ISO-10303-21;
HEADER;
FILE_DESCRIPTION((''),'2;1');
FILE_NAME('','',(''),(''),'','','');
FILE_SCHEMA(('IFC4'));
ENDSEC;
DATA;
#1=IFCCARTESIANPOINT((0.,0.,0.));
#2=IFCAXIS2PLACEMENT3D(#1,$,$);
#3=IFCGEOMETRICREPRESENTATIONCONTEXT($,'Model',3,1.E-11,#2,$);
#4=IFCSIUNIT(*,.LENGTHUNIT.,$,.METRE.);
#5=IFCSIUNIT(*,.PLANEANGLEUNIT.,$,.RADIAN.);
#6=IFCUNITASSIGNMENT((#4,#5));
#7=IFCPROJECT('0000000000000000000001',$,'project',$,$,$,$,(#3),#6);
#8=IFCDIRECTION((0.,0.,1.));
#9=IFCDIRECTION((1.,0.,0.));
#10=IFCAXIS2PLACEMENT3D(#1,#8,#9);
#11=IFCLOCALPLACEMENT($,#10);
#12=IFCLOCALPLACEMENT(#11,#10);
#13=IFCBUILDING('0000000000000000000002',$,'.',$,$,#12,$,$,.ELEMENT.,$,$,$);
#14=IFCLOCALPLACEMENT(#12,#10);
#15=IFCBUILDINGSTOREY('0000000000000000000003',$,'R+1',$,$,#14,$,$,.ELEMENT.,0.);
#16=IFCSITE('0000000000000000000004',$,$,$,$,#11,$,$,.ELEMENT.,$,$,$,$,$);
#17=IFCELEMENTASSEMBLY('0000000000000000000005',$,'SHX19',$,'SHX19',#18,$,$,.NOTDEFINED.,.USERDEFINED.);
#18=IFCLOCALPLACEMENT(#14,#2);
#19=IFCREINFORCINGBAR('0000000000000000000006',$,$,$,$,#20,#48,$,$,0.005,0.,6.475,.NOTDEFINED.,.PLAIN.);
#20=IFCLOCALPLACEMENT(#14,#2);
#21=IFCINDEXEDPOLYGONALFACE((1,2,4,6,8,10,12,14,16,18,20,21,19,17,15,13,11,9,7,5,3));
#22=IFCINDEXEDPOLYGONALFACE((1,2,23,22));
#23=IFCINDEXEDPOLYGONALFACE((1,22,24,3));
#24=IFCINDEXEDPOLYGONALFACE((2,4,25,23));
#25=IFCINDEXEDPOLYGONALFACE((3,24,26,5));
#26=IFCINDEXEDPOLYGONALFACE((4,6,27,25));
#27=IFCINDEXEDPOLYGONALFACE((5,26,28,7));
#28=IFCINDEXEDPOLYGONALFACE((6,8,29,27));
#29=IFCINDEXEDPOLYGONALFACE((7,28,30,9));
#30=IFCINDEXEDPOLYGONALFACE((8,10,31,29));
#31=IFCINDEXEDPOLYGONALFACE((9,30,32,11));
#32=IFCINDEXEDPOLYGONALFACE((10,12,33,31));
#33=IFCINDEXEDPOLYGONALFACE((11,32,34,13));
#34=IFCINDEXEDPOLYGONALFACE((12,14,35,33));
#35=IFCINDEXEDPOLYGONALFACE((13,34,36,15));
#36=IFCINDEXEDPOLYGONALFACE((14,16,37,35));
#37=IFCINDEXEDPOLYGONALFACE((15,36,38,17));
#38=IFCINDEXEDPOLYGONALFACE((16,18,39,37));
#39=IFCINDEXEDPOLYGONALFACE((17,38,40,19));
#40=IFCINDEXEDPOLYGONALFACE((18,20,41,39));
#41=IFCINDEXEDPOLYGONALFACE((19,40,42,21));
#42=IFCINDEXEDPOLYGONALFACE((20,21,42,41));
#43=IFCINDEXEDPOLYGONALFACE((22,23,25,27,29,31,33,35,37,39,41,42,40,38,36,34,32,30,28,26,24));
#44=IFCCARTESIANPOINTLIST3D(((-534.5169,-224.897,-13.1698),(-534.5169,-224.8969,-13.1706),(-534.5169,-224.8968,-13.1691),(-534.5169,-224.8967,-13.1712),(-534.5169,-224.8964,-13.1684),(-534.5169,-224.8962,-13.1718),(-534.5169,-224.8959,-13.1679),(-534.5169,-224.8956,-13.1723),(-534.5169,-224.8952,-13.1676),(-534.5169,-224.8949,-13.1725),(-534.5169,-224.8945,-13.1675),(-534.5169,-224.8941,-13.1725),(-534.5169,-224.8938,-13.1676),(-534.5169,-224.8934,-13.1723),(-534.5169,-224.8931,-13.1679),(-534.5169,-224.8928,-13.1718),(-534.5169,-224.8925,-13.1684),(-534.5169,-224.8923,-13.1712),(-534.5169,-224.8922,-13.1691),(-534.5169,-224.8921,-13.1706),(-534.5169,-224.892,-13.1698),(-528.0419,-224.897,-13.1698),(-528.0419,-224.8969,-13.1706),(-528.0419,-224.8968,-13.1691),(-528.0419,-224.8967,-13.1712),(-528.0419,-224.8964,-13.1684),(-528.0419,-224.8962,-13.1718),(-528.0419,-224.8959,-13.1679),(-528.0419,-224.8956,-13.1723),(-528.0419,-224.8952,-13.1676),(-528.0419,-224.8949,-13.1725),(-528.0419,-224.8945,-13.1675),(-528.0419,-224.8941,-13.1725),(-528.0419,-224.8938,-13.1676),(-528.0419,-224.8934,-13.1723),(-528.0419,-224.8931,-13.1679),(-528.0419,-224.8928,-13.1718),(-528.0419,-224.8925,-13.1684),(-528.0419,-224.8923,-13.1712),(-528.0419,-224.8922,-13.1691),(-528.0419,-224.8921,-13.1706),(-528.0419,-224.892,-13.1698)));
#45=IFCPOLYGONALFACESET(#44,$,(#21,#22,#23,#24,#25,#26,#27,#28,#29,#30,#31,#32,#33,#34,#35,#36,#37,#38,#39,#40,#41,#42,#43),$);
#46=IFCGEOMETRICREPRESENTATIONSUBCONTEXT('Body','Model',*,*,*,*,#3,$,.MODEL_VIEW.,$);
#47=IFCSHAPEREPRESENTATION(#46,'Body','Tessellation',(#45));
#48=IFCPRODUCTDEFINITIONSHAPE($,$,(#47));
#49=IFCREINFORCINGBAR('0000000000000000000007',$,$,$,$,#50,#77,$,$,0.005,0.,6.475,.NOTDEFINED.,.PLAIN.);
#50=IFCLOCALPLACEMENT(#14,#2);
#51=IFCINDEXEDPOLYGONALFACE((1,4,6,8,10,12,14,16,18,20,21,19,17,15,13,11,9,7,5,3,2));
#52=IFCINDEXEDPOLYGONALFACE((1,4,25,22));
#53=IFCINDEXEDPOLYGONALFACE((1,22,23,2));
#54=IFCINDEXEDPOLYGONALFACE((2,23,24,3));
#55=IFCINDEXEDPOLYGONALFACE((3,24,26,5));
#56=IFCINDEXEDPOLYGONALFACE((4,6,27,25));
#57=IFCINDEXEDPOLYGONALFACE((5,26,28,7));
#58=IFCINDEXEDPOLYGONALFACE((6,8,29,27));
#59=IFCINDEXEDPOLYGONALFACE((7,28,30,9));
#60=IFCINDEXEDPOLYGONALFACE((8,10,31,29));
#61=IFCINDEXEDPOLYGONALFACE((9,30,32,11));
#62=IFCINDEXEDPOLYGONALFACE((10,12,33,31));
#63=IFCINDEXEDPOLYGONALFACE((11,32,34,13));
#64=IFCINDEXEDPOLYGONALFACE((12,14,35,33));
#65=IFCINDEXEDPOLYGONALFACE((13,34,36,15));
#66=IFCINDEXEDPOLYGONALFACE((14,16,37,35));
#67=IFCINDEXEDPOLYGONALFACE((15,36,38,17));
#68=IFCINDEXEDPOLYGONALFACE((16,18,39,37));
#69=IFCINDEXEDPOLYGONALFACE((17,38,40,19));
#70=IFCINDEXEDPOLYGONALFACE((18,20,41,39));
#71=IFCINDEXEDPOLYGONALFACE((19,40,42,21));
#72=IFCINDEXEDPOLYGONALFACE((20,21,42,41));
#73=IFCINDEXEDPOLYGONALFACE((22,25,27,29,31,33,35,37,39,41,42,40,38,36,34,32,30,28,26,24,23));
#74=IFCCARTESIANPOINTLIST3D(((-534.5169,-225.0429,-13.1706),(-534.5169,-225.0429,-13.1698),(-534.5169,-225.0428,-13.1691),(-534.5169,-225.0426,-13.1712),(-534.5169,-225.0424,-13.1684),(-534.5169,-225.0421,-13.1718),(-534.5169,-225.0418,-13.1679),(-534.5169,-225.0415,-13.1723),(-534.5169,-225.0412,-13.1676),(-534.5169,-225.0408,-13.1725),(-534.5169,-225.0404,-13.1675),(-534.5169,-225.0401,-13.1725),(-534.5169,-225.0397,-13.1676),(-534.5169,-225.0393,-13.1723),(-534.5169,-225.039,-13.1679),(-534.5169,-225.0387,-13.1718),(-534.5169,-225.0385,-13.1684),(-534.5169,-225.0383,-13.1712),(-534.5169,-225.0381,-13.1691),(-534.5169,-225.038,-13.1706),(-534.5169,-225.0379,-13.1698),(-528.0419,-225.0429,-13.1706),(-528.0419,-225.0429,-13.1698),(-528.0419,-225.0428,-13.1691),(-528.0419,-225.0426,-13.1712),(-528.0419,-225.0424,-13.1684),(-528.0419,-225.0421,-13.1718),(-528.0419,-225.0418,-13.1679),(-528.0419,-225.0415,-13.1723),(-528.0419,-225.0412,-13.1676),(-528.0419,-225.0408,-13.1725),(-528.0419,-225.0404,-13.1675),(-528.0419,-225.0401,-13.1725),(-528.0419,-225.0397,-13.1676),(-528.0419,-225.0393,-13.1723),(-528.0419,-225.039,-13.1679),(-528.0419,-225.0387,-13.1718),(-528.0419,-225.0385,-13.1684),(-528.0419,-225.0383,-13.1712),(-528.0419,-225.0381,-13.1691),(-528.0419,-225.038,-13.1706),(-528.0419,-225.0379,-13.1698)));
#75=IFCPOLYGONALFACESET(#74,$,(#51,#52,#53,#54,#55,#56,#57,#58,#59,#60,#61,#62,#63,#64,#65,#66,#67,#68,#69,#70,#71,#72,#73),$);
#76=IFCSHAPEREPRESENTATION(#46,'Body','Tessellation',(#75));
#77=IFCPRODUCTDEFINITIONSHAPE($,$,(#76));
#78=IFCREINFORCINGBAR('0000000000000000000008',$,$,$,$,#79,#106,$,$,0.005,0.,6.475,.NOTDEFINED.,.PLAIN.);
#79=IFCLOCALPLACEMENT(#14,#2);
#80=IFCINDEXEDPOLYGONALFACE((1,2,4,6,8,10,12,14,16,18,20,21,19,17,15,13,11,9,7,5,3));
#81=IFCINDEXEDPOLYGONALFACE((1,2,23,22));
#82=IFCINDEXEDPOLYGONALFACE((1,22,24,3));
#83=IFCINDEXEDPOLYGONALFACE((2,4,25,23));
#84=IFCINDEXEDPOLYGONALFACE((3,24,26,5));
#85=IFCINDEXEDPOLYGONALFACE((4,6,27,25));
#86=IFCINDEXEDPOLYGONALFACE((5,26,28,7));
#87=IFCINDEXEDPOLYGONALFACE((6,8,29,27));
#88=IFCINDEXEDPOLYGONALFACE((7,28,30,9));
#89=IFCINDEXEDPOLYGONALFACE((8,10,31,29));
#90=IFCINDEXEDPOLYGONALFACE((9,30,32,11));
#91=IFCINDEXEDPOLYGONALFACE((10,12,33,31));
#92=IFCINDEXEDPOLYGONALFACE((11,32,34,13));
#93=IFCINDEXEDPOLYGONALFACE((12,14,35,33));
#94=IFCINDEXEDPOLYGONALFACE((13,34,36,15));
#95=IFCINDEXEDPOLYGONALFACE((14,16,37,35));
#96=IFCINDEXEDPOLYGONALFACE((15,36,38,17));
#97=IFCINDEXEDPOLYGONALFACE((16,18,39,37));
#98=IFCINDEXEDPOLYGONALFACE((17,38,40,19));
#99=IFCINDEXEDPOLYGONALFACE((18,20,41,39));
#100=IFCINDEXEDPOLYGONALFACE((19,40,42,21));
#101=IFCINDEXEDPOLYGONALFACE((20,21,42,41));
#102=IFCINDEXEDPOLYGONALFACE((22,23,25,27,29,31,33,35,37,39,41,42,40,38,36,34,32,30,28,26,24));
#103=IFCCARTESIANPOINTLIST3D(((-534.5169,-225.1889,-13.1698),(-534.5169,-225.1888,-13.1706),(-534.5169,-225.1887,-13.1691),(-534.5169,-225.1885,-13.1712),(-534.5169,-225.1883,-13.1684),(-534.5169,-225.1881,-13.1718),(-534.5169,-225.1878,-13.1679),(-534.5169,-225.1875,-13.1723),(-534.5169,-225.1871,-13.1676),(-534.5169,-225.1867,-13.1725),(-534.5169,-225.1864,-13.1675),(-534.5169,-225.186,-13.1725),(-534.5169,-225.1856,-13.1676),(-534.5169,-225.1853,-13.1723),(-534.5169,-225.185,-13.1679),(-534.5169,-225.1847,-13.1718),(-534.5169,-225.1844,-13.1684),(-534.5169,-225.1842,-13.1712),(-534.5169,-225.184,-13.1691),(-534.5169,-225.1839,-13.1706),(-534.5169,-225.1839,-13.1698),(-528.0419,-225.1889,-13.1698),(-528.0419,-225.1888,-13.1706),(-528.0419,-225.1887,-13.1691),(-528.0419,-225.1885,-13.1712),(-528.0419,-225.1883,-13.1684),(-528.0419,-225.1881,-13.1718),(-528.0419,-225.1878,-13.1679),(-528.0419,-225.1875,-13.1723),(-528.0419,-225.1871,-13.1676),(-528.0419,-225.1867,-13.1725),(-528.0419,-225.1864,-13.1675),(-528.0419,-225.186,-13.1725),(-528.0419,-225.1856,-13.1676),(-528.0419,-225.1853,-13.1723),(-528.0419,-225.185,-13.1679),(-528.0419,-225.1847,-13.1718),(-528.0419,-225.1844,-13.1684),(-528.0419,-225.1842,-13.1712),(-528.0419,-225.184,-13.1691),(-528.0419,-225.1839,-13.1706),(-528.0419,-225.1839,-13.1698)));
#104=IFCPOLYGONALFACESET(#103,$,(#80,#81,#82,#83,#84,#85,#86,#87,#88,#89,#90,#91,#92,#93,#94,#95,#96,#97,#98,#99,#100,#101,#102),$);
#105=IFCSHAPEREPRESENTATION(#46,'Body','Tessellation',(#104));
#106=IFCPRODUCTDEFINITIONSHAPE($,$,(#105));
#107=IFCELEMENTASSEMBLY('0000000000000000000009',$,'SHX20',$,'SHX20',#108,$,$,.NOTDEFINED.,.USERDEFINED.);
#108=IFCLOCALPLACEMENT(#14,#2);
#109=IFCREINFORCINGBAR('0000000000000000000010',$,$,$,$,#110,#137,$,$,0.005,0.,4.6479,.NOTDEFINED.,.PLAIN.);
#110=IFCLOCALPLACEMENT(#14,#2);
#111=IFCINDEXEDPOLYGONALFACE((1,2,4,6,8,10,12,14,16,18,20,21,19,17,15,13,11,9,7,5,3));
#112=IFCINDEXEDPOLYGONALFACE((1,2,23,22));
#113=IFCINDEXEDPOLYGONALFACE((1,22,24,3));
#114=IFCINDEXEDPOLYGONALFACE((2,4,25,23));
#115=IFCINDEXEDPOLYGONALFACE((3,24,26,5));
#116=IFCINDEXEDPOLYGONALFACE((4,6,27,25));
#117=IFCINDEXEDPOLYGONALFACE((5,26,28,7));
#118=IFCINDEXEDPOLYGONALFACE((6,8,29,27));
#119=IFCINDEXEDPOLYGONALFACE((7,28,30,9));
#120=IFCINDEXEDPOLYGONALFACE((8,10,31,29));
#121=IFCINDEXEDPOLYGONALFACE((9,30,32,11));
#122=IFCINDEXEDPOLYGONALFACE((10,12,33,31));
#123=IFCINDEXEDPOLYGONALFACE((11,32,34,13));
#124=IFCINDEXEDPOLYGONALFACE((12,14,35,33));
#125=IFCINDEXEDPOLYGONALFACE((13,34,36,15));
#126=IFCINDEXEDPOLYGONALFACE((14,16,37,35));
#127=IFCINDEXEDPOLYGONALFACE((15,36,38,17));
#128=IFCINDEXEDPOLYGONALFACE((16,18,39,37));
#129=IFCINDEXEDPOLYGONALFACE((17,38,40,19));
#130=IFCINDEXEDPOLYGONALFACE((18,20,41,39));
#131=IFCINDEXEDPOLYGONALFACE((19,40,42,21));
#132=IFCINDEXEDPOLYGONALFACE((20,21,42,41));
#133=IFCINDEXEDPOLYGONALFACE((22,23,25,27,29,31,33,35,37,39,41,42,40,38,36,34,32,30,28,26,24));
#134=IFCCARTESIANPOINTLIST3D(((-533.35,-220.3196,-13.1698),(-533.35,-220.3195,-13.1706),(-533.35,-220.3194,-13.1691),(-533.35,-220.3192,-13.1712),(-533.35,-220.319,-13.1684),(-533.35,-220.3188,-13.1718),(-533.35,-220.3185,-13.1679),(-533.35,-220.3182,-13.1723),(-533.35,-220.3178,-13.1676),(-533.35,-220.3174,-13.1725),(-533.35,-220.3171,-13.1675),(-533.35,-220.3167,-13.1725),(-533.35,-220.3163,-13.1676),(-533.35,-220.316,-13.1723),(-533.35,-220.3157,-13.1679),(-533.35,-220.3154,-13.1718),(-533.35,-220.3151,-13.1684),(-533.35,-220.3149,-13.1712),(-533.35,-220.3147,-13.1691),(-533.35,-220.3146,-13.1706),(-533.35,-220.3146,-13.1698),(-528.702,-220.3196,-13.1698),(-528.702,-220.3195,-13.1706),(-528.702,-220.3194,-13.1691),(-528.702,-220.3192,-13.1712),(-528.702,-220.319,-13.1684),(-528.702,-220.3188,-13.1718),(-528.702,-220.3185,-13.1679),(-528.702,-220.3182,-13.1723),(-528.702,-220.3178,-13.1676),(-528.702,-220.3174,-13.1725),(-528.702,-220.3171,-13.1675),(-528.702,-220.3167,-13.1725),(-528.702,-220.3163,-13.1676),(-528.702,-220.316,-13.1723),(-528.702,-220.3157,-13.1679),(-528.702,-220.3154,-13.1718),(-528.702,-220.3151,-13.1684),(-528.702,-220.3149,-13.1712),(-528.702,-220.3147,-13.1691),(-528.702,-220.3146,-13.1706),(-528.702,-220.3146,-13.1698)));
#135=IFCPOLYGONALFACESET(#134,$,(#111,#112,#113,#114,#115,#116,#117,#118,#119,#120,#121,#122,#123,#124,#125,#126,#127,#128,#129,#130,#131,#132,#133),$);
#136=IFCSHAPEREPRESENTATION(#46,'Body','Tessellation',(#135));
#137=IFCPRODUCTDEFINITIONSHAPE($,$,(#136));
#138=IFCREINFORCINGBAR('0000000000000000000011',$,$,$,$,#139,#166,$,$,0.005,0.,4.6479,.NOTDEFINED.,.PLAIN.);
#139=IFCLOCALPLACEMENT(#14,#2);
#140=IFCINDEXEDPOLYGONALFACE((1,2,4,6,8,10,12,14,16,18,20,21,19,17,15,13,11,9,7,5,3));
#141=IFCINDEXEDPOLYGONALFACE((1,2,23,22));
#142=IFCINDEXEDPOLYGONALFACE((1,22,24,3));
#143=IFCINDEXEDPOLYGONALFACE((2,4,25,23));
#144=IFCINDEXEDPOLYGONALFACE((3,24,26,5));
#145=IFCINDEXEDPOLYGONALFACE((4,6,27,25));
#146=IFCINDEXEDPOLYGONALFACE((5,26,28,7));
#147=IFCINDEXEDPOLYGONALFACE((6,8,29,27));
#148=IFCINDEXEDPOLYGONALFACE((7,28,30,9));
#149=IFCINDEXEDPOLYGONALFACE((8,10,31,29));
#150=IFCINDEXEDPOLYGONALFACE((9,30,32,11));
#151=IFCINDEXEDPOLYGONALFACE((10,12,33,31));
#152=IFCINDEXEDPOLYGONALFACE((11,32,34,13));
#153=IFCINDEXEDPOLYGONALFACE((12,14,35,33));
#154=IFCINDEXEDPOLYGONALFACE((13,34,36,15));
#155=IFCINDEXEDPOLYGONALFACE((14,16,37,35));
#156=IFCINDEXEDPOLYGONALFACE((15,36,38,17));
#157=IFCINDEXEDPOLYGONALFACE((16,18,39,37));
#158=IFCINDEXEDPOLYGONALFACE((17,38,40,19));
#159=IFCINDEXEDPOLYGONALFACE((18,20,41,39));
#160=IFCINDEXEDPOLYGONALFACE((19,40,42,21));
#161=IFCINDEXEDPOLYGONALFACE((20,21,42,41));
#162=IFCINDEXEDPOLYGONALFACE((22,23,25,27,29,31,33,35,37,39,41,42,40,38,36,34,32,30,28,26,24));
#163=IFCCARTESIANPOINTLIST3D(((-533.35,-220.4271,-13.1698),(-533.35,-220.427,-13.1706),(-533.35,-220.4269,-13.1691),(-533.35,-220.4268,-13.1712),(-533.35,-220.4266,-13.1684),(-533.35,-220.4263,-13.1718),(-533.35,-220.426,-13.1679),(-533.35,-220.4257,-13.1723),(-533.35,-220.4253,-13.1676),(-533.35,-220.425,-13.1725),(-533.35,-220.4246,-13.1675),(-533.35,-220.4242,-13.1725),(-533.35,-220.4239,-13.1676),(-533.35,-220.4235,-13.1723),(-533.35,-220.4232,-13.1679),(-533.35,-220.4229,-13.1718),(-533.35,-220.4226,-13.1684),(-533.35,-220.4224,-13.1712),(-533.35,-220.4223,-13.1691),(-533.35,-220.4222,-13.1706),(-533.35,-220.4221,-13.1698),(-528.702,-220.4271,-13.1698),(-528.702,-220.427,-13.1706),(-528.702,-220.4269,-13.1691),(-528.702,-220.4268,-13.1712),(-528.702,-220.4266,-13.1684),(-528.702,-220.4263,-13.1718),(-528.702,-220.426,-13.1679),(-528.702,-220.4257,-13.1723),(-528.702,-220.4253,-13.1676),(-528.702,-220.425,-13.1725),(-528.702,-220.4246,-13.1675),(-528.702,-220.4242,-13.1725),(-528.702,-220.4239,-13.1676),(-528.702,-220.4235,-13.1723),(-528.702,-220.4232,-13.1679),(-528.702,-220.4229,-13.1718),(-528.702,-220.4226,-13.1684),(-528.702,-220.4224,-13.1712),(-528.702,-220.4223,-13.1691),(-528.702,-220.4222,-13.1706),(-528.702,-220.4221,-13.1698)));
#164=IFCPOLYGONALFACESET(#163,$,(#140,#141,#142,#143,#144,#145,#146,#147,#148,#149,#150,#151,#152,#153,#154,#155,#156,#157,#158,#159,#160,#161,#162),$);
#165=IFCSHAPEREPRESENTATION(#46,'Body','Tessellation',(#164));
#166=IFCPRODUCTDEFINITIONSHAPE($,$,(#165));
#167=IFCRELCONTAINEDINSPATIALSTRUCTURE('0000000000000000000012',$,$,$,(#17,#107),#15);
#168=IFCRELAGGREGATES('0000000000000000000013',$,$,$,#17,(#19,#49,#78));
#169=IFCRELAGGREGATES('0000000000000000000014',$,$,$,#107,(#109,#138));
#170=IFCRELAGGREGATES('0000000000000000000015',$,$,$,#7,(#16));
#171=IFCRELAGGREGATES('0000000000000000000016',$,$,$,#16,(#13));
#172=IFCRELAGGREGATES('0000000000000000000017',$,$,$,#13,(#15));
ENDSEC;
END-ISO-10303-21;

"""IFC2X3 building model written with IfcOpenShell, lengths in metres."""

from ifc_helpers import new_model, entity, si_unit, origin, origin_with_axes, place, context, subcontext, project, spatial, shape, element, aggregate, save


model = new_model("IFC2X3")

# Units and contexts
model_context = context("Model", 3, precision=1e-11, world=origin())
body_context = subcontext(model_context, "Body", "Model", "MODEL_VIEW")
ifc_project = project(units=[si_unit("LENGTHUNIT", "METRE"), si_unit("PLANEANGLEUNIT", "RADIAN")], contexts=[model_context])

# Site, building, storey
site_placement = place(None, origin_with_axes())
site = spatial("IfcSite", under=ifc_project, at=site_placement, CompositionType="ELEMENT")
building_placement = place(site_placement, origin_with_axes())
building = spatial("IfcBuilding", under=site, at=building_placement, Name=".", CompositionType="ELEMENT")
storey_placement = place(building_placement, origin_with_axes())
storey = spatial("IfcBuildingStorey", under=building, at=storey_placement, Name="R+1", CompositionType="ELEMENT", Elevation=0.0)

# Element assemblies, reinforcing bars
assembly_1_placement = place(storey_placement, origin_with_axes())
assembly_1 = element("IfcElementAssembly", 1, at=assembly_1_placement, inside=storey, Name="SHX19", ObjectType="SHX19", AssemblyPlace="NOTDEFINED", PredefinedType="USERDEFINED")
reinforcing_bar_1_placement = place(assembly_1_placement, origin_with_axes())
reinforcing_bar_1 = element("IfcReinforcingBar", 2, at=reinforcing_bar_1_placement, BarLength=6.475, BarRole="NOTDEFINED", BarSurface="PLAIN", CrossSectionArea=0.0, NominalDiameter=0.005, shapes=[
    shape(body_context, "Body", "AdvancedSweptSolid", [entity("IfcSweptDiskSolid", entity("IfcPolyline", [entity("IfcCartesianPoint", [528.0419, 224.8945, 13.17]), entity("IfcCartesianPoint", [534.5169, 224.8945, 13.17])]), 0.0025, None, 0.0, 6.475)]),
    shape(body_context, "Body", "AdvancedSweptSolid", [entity("IfcSweptDiskSolid", entity("IfcPolyline", [entity("IfcCartesianPoint", [528.0419, 224.8945, 13.17]), entity("IfcCartesianPoint", [534.5169, 224.8945, 13.17])]), 0.0025, None, 0.0, 6.475)]),
])
reinforcing_bar_2_placement = place(assembly_1_placement, origin_with_axes())
reinforcing_bar_2 = element("IfcReinforcingBar", 3, at=reinforcing_bar_2_placement, BarLength=6.475, BarRole="NOTDEFINED", BarSurface="PLAIN", CrossSectionArea=0.0, NominalDiameter=0.005, shapes=[
    shape(body_context, "Body", "AdvancedSweptSolid", [entity("IfcSweptDiskSolid", entity("IfcPolyline", [entity("IfcCartesianPoint", [528.0419, 225.0404, 13.17]), entity("IfcCartesianPoint", [534.5169, 225.0404, 13.17])]), 0.0025, None, 0.0, 6.475)]),
    shape(body_context, "Body", "AdvancedSweptSolid", [entity("IfcSweptDiskSolid", entity("IfcPolyline", [entity("IfcCartesianPoint", [528.0419, 225.0404, 13.17]), entity("IfcCartesianPoint", [534.5169, 225.0404, 13.17])]), 0.0025, None, 0.0, 6.475)]),
])
reinforcing_bar_3_placement = place(assembly_1_placement, origin_with_axes())
reinforcing_bar_3 = element("IfcReinforcingBar", 4, at=reinforcing_bar_3_placement, BarLength=6.475, BarRole="NOTDEFINED", BarSurface="PLAIN", CrossSectionArea=0.0, NominalDiameter=0.005, shapes=[
    shape(body_context, "Body", "AdvancedSweptSolid", [entity("IfcSweptDiskSolid", entity("IfcPolyline", [entity("IfcCartesianPoint", [528.0419, 225.1864, 13.17]), entity("IfcCartesianPoint", [534.5169, 225.1864, 13.17])]), 0.0025, None, 0.0, 6.475)]),
    shape(body_context, "Body", "AdvancedSweptSolid", [entity("IfcSweptDiskSolid", entity("IfcPolyline", [entity("IfcCartesianPoint", [528.0419, 225.1864, 13.17]), entity("IfcCartesianPoint", [534.5169, 225.1864, 13.17])]), 0.0025, None, 0.0, 6.475)]),
])
aggregate(assembly_1, [reinforcing_bar_1, reinforcing_bar_2, reinforcing_bar_3])
assembly_2_placement = place(storey_placement, origin_with_axes())
assembly_2 = element("IfcElementAssembly", 5, at=assembly_2_placement, inside=storey, Name="SHX20", ObjectType="SHX20", AssemblyPlace="NOTDEFINED", PredefinedType="USERDEFINED")
reinforcing_bar_4_placement = place(assembly_2_placement, origin_with_axes())
reinforcing_bar_4 = element("IfcReinforcingBar", 6, at=reinforcing_bar_4_placement, BarLength=4.6479, BarRole="NOTDEFINED", BarSurface="PLAIN", CrossSectionArea=0.0, NominalDiameter=0.005, shapes=[
    shape(body_context, "Body", "AdvancedSweptSolid", [entity("IfcSweptDiskSolid", entity("IfcPolyline", [entity("IfcCartesianPoint", [528.702, 220.3171, 13.17]), entity("IfcCartesianPoint", [533.35, 220.3171, 13.17])]), 0.0025, None, 0.0, 4.6479)]),
    shape(body_context, "Body", "AdvancedSweptSolid", [entity("IfcSweptDiskSolid", entity("IfcPolyline", [entity("IfcCartesianPoint", [528.702, 220.3171, 13.17]), entity("IfcCartesianPoint", [533.35, 220.3171, 13.17])]), 0.0025, None, 0.0, 4.6479)]),
])
reinforcing_bar_5_placement = place(assembly_2_placement, origin_with_axes())
reinforcing_bar_5 = element("IfcReinforcingBar", 7, at=reinforcing_bar_5_placement, BarLength=4.6479, BarRole="NOTDEFINED", BarSurface="PLAIN", CrossSectionArea=0.0, NominalDiameter=0.005, shapes=[
    shape(body_context, "Body", "AdvancedSweptSolid", [entity("IfcSweptDiskSolid", entity("IfcPolyline", [entity("IfcCartesianPoint", [528.702, 220.4246, 13.17]), entity("IfcCartesianPoint", [533.35, 220.4246, 13.17])]), 0.0025, None, 0.0, 4.6479)]),
    shape(body_context, "Body", "AdvancedSweptSolid", [entity("IfcSweptDiskSolid", entity("IfcPolyline", [entity("IfcCartesianPoint", [528.702, 220.4246, 13.17]), entity("IfcCartesianPoint", [533.35, 220.4246, 13.17])]), 0.0025, None, 0.0, 4.6479)]),
])
aggregate(assembly_2, [reinforcing_bar_4, reinforcing_bar_5])

save(model, "model.ifc")
